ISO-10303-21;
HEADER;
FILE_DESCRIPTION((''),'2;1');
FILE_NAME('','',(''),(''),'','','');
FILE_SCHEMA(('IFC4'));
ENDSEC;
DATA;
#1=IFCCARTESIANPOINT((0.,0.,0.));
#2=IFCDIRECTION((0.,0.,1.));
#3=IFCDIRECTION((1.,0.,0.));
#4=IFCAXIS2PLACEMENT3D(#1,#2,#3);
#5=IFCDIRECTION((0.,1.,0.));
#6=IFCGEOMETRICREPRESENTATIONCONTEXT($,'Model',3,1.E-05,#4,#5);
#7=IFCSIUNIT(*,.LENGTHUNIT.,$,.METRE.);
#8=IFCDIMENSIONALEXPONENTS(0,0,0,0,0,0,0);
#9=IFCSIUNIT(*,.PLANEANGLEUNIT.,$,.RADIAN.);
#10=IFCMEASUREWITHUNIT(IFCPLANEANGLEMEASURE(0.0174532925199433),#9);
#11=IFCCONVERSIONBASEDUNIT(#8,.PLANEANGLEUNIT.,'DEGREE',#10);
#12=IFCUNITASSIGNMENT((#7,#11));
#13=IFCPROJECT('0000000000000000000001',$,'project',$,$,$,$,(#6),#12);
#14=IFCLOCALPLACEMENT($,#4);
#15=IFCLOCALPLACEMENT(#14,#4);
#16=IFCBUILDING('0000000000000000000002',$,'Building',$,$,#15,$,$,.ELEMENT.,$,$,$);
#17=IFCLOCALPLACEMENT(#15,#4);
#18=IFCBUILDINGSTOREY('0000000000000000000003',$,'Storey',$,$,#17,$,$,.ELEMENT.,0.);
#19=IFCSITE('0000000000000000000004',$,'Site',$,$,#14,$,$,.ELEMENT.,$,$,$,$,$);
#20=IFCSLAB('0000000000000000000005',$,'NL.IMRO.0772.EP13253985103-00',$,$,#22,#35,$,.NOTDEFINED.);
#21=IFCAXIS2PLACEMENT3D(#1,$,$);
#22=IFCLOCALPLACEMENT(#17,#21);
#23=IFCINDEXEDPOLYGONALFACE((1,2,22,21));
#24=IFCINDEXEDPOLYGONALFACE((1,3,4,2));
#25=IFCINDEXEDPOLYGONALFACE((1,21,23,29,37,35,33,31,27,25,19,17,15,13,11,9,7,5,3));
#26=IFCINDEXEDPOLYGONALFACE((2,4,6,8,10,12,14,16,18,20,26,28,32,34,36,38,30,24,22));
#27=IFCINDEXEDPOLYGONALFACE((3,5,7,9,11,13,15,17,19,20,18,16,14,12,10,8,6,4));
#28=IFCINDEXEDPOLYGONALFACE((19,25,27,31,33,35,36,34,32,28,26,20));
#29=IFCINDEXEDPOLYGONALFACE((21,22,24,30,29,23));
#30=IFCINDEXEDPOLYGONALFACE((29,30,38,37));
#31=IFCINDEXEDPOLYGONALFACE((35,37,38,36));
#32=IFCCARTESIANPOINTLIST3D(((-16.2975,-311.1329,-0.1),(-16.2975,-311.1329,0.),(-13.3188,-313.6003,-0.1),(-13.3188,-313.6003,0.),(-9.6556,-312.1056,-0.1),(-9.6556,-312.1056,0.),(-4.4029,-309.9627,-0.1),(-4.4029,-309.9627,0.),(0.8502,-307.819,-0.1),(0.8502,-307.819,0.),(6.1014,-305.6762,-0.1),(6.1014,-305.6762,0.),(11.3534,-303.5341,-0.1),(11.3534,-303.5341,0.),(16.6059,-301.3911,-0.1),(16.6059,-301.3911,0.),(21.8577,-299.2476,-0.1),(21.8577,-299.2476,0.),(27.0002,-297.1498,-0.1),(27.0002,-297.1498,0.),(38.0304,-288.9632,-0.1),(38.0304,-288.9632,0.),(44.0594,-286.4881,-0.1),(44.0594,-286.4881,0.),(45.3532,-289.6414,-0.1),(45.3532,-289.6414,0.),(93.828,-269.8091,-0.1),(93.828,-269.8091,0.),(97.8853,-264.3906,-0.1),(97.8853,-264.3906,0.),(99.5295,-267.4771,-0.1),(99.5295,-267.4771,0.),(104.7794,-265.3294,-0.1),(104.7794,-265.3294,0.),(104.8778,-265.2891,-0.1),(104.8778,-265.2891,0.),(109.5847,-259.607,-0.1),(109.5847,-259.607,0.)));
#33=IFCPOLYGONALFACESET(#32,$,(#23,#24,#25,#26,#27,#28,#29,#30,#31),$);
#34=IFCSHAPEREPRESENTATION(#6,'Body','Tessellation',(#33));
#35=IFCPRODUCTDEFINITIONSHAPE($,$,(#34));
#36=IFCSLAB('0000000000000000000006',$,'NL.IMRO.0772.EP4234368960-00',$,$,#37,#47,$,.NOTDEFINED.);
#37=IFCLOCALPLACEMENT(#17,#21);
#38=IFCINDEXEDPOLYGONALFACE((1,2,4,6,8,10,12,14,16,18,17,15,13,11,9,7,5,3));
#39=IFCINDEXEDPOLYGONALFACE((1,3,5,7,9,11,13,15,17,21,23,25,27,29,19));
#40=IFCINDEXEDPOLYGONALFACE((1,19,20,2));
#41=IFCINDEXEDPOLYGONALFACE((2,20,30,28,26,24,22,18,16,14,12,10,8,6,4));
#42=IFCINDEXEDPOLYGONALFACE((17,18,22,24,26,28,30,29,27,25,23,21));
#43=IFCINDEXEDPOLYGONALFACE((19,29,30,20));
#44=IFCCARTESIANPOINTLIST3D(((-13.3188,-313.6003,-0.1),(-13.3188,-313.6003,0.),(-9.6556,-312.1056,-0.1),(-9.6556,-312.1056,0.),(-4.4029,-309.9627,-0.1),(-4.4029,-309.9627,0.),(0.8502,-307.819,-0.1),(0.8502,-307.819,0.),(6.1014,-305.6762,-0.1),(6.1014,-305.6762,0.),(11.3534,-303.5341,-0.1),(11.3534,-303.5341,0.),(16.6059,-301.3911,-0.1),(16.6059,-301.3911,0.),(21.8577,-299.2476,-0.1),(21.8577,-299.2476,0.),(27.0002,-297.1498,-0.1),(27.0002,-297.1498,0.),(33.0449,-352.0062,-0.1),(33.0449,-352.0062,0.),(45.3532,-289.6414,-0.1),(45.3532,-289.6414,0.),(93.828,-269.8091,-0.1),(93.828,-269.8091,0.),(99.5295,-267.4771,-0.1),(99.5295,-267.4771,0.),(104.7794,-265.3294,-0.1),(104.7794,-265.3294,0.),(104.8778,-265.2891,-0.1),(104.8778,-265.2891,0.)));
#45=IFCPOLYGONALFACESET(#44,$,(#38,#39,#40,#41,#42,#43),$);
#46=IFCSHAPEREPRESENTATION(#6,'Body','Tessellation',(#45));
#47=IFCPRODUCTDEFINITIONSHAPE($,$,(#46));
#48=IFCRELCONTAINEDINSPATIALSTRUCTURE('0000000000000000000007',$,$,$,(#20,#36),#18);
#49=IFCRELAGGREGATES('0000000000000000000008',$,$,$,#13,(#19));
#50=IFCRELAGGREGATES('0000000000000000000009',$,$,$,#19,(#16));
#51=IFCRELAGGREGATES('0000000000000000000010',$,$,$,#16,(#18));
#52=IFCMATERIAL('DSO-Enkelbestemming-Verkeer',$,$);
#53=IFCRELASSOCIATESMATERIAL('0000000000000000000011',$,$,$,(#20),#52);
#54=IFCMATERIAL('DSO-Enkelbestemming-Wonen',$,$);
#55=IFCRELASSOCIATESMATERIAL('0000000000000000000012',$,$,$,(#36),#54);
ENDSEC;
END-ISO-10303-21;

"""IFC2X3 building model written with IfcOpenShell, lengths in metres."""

from ifc_helpers import new_model, entity, si_unit, converted_unit, direction, frame, origin_with_axes, place, context, project, spatial, polyline, outline, extrude, material, element, save


model = new_model("IFC2X3")

# Units and contexts
model_context = context("Model", 3, precision=1e-05, world=origin_with_axes(), true_north=direction((0.0, 1.0, 0.0)))
ifc_project = project(units=[si_unit("LENGTHUNIT", "METRE"), converted_unit("PLANEANGLEUNIT", "DEGREE", entity("IfcPlaneAngleMeasure", 0.0174532925199433), si_unit("PLANEANGLEUNIT", "RADIAN"), dimensions=[0, 0, 0, 0, 0, 0, 0])], contexts=[model_context])

# Site, building, storey
site_placement = place(None, origin_with_axes())
site = spatial("IfcSite", under=ifc_project, at=site_placement, Name="Site", CompositionType="ELEMENT")
building_placement = place(site_placement, origin_with_axes())
building = spatial("IfcBuilding", under=site, at=building_placement, Name="Building", CompositionType="ELEMENT")
storey_placement = place(building_placement, origin_with_axes())
storey = spatial("IfcBuildingStorey", under=building, at=storey_placement, Name="Storey", CompositionType="ELEMENT", Elevation=0.0)

# Slabs
ifc_material_1 = material(Name="DSO-Enkelbestemming-Verkeer")
slab_1_placement = place(storey_placement, frame((0.0, 0.0, -0.1), z_axis=(0.0, 0.0, 1.0), x_axis=(1.0, 0.0, 0.0)))
element("IfcSlab", 1, at=slab_1_placement, inside=storey, material=ifc_material_1, Name="NL.IMRO.0772.EP13253985103-00", PredefinedType="NOTDEFINED", context=model_context, shape_type="SweptSolid", body=[
    extrude(outline(polyline([(38.0304, -288.9632), (44.0594, -286.4881), (97.8853, -264.3906), (109.5847, -259.607), (104.8778, -265.2891), (104.7794, -265.3294), (99.5295, -267.4771), (93.828, -269.8091), (45.3532, -289.6414), (27.0002, -297.1498), (21.8577, -299.2476), (16.6059, -301.3911), (11.3534, -303.5341), (6.1014, -305.6762), (0.8502, -307.819), (-4.4029, -309.9627), (-9.6556, -312.1056), (-13.3188, -313.6003), (-16.2975, -311.1329), (38.0304, -288.9632)])), origin_with_axes(), (0.0, 0.0, 1.0), 0.1),
])
ifc_material_2 = material(Name="DSO-Enkelbestemming-Wonen")
slab_2_placement = place(storey_placement, frame((0.0, 0.0, -0.1), z_axis=(0.0, 0.0, 1.0), x_axis=(1.0, 0.0, 0.0)))
element("IfcSlab", 2, at=slab_2_placement, inside=storey, material=ifc_material_2, Name="NL.IMRO.0772.EP4234368960-00", PredefinedType="NOTDEFINED", context=model_context, shape_type="SweptSolid", body=[
    extrude(outline(polyline([(-9.6556, -312.1056), (-4.4029, -309.9627), (0.8502, -307.819), (6.1014, -305.6762), (11.3534, -303.5341), (16.6059, -301.3911), (21.8577, -299.2476), (27.0002, -297.1498), (45.3532, -289.6414), (93.828, -269.8091), (99.5295, -267.4771), (104.7794, -265.3294), (104.8778, -265.2891), (33.0449, -352.0062), (-13.3188, -313.6003), (-9.6556, -312.1056)])), origin_with_axes(), (0.0, 0.0, 1.0), 0.1),
])

save(model, "model.ifc")
